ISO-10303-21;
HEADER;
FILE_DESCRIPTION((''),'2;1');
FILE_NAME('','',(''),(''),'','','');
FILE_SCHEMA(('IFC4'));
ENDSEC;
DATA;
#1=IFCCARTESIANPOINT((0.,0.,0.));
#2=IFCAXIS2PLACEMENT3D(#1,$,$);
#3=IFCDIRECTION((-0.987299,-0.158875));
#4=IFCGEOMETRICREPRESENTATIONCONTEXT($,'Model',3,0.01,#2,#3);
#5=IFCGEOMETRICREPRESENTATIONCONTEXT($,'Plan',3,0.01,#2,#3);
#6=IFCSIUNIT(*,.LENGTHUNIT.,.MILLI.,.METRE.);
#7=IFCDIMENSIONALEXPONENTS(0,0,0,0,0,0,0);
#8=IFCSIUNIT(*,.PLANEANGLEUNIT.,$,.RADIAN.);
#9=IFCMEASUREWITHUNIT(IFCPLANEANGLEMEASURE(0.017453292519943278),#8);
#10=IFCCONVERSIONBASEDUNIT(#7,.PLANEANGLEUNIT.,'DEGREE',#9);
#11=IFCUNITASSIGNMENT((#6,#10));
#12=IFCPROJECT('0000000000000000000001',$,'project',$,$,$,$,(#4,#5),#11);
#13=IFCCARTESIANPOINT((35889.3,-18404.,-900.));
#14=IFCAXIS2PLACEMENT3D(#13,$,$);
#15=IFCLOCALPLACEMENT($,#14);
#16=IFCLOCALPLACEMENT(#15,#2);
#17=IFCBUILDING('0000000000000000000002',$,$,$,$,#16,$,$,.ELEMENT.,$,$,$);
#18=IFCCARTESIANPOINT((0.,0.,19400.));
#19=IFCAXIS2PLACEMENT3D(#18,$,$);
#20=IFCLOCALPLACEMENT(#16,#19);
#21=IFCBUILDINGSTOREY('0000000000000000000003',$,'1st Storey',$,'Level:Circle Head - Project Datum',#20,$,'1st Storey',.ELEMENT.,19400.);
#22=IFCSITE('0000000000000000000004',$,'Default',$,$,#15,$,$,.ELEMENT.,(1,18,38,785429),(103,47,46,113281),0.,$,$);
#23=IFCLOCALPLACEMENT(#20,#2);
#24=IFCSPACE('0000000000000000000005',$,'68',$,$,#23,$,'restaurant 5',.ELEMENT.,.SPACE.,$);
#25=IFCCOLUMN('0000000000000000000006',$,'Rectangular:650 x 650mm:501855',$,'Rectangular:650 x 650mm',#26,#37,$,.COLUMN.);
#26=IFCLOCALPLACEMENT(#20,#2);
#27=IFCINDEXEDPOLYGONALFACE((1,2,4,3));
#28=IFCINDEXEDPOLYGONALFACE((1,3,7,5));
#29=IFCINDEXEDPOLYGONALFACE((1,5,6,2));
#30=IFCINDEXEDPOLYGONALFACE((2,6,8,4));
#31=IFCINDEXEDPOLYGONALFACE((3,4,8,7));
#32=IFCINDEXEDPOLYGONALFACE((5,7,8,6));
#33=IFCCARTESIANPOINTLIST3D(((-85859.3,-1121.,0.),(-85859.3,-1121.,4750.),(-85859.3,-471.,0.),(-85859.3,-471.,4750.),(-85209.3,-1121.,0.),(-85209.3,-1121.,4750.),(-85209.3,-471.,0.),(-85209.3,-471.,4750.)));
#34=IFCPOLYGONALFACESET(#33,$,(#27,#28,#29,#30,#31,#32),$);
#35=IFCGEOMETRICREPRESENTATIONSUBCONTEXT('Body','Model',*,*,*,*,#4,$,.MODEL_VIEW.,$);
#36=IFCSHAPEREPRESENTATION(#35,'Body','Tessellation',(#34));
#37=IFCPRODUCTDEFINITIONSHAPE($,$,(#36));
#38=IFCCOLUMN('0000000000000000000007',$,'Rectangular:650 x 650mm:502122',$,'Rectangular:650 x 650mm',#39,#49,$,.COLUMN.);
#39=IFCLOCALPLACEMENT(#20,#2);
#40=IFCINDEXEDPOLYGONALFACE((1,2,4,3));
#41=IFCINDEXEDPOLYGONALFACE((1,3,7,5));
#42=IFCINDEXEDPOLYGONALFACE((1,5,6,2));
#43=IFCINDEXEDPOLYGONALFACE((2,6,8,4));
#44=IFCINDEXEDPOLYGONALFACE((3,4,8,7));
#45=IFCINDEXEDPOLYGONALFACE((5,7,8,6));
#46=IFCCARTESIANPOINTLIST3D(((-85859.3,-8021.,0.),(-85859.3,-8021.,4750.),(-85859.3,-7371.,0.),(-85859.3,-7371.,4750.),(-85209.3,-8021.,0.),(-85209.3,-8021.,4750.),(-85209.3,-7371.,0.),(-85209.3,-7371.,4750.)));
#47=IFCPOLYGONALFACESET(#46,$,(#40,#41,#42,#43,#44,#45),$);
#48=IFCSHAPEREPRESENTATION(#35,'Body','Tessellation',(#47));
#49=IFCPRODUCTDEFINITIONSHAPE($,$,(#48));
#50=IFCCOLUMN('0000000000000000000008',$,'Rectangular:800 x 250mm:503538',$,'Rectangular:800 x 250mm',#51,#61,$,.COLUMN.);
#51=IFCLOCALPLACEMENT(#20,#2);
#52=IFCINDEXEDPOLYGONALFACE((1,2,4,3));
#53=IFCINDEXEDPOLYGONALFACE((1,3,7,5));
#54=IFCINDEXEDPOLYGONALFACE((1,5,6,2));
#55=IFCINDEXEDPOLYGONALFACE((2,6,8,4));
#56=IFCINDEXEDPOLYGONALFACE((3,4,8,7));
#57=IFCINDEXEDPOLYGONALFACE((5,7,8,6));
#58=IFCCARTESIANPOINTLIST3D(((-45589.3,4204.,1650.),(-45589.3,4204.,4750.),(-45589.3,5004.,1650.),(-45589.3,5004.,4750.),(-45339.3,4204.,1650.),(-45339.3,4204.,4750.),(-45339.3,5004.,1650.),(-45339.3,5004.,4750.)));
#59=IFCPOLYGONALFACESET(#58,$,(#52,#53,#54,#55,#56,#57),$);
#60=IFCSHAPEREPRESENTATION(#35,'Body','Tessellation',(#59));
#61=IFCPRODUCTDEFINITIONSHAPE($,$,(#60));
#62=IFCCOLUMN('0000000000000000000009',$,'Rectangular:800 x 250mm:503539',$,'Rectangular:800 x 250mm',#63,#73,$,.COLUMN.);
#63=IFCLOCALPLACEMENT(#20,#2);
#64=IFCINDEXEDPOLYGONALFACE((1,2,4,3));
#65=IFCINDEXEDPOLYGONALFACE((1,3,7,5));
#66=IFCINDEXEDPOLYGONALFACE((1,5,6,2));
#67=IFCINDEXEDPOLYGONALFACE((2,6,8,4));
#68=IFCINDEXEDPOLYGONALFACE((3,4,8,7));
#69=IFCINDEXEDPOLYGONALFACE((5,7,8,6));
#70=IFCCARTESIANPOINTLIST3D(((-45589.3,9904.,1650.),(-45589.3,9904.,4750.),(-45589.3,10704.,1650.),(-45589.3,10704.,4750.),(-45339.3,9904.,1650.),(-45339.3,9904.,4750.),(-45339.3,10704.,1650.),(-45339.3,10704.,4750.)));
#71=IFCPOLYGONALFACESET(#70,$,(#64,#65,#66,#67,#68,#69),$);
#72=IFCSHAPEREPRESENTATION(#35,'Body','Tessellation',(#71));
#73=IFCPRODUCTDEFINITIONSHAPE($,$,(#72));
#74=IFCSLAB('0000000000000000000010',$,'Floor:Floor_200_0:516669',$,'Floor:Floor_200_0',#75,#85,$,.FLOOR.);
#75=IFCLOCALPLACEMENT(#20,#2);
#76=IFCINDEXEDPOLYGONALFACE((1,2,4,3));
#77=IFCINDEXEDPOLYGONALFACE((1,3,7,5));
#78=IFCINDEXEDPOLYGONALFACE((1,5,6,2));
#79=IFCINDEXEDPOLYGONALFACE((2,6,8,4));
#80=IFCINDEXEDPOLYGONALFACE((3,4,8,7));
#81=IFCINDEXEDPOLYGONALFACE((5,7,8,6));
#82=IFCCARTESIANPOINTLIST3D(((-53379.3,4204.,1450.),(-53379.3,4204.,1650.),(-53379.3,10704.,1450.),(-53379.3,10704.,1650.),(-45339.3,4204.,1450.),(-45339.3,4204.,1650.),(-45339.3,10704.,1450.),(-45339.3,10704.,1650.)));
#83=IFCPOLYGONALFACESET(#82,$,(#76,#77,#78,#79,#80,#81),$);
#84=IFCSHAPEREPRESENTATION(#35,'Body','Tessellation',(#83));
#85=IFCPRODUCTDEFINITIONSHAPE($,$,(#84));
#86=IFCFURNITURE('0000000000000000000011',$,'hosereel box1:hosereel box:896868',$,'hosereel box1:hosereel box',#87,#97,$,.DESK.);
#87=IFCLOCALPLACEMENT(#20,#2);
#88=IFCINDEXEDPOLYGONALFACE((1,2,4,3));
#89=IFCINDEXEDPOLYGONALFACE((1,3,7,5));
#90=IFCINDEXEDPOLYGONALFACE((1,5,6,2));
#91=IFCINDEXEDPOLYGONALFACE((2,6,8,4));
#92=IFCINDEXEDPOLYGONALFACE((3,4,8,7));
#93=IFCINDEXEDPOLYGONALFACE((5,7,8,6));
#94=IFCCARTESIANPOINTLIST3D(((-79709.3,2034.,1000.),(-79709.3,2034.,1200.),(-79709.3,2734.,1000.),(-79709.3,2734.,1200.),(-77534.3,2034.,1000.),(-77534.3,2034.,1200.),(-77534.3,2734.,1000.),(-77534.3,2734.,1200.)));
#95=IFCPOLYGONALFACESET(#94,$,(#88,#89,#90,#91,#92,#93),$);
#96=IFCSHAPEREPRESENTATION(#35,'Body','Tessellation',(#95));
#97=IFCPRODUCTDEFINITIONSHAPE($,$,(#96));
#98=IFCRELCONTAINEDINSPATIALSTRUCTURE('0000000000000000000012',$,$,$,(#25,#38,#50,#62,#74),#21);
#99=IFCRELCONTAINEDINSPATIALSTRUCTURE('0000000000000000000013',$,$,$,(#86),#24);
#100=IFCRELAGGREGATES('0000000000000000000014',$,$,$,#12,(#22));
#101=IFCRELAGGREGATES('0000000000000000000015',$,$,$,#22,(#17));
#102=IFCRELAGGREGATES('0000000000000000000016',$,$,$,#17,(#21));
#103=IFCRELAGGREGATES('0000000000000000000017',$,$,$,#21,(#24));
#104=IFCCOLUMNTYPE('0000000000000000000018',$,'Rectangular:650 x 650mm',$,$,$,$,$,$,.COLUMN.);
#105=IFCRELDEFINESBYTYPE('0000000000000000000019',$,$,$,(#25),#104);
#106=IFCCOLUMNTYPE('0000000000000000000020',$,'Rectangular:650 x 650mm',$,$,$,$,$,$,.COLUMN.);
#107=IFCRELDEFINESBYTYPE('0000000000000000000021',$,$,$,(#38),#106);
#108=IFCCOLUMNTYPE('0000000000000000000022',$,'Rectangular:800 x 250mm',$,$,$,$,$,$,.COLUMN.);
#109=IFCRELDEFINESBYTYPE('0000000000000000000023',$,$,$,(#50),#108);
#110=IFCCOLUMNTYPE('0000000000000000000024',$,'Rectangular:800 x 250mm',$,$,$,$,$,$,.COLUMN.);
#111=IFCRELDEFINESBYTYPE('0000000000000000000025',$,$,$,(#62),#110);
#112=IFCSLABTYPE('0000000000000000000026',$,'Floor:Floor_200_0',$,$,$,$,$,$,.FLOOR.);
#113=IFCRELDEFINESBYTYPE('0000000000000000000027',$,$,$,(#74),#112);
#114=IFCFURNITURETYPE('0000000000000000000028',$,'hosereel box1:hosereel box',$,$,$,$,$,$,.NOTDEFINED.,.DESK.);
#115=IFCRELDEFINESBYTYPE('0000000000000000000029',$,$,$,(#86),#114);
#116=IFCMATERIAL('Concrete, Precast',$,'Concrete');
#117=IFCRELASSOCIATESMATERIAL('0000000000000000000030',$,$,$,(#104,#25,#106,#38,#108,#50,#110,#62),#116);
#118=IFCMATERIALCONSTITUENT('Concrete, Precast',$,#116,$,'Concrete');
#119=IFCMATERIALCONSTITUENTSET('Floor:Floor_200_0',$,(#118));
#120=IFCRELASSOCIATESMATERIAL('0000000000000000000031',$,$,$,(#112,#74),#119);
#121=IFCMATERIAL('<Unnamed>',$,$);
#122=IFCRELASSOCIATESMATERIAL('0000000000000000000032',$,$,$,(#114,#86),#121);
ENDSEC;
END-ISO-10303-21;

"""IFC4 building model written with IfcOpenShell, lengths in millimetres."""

from ifc_helpers import new_model, entity, si_unit, converted_unit, direction, frame, origin, place, context, subcontext, project, spatial, indexed_curve, outline, extrude, source, transform, mapped, material, constituent, constituent_set, type_object, type_shapes, element, save


model = new_model("IFC4")

# Units and contexts
model_context = context("Model", 3, precision=0.01, world=origin(), true_north=direction((-0.987299, -0.158875)))
plan_context = context("Plan", 3, precision=0.01, world=origin(), true_north=direction((-0.987299, -0.158875)))
body_context = subcontext(model_context, "Body", "Model", "MODEL_VIEW")
ifc_project = project(units=[si_unit("LENGTHUNIT", "METRE", prefix="MILLI"), converted_unit("PLANEANGLEUNIT", "DEGREE", entity("IfcPlaneAngleMeasure", 0.017453292519943278), si_unit("PLANEANGLEUNIT", "RADIAN"), dimensions=[0, 0, 0, 0, 0, 0, 0])], contexts=[model_context, plan_context])

# Site, building, storey
site_placement = place(None, frame((35889.3, -18404.0, -900.0)))
site = spatial("IfcSite", under=ifc_project, at=site_placement, Name="Default", CompositionType="ELEMENT", RefLatitude=(1, 18, 38, 785429), RefLongitude=(103, 47, 46, 113281), RefElevation=0.0)
building_placement = place(site_placement, origin())
building = spatial("IfcBuilding", under=site, at=building_placement, CompositionType="ELEMENT")
storey_placement = place(building_placement, frame((0.0, 0.0, 19400.0)))
storey = spatial("IfcBuildingStorey", under=building, at=storey_placement, Name="1st Storey", ObjectType="Level:Circle Head - Project Datum", LongName="1st Storey", CompositionType="ELEMENT", Elevation=19400.0)

# Columns
ifc_material_1 = material(Name="Concrete, Precast", Category="Concrete")
column_type_1 = type_object("IfcColumnType", Name="Rectangular:650 x 650mm", PredefinedType="COLUMN", material=ifc_material_1)
shared_shape_1 = source(origin(), body_context, "Body", "SweptSolid", [
    extrude(outline(indexed_curve([(-325.0, -325.0), (325.0, -325.0), (325.0, 325.0), (-325.0, 325.0), (-325.0, -325.0)], self_intersect=False)), frame((-85534.3, -796.0, 19400.0), z_axis=(0.0, 0.0, 1.0), x_axis=(0.0, 1.0, 0.0)), (0.0, 0.0, 1.0), 4750.0),
])
type_shapes(column_type_1, [shared_shape_1])
column_1_placement = place(storey_placement, frame((0.0, 0.0, -19400.0)))
element("IfcColumn", 1, at=column_1_placement, inside=storey, type_object=column_type_1, material=ifc_material_1, Name="Rectangular:650 x 650mm:501855", ObjectType="Rectangular:650 x 650mm", PredefinedType="COLUMN", context=body_context, shape_type="MappedRepresentation", body=[
    mapped(shared_shape_1, transform((0.0, 0.0, 0.0), scale=1.0)),
])
column_type_2 = type_object("IfcColumnType", Name="Rectangular:650 x 650mm", PredefinedType="COLUMN", material=ifc_material_1)
shared_shape_2 = source(origin(), body_context, "Body", "SweptSolid", [
    extrude(outline(indexed_curve([(-325.0, -325.0), (325.0, -325.0), (325.0, 325.0), (-325.0, 325.0), (-325.0, -325.0)], self_intersect=False)), frame((-85534.3, -7696.0, 19400.0), z_axis=(0.0, 0.0, 1.0), x_axis=(0.0, 1.0, 0.0)), (0.0, 0.0, 1.0), 4750.0),
])
type_shapes(column_type_2, [shared_shape_2])
column_2_placement = place(storey_placement, frame((0.0, 0.0, -19400.0)))
element("IfcColumn", 2, at=column_2_placement, inside=storey, type_object=column_type_2, material=ifc_material_1, Name="Rectangular:650 x 650mm:502122", ObjectType="Rectangular:650 x 650mm", PredefinedType="COLUMN", context=body_context, shape_type="MappedRepresentation", body=[
    mapped(shared_shape_2, transform((0.0, 0.0, 0.0), scale=1.0)),
])
column_type_3 = type_object("IfcColumnType", Name="Rectangular:800 x 250mm", PredefinedType="COLUMN", material=ifc_material_1)
shared_shape_3 = source(origin(), body_context, "Body", "SweptSolid", [
    extrude(outline(indexed_curve([(-125.0, -400.0), (125.0, -400.0), (125.0, 400.0), (-125.0, 400.0), (-125.0, -400.0)], self_intersect=False)), frame((-45464.3, 4604.0, 21050.0)), (0.0, 0.0, 1.0), 3100.0),
])
type_shapes(column_type_3, [shared_shape_3])
column_3_placement = place(storey_placement, frame((0.0, 0.0, -19400.0)))
element("IfcColumn", 3, at=column_3_placement, inside=storey, type_object=column_type_3, material=ifc_material_1, Name="Rectangular:800 x 250mm:503538", ObjectType="Rectangular:800 x 250mm", PredefinedType="COLUMN", context=body_context, shape_type="MappedRepresentation", body=[
    mapped(shared_shape_3, transform((0.0, 0.0, 0.0), scale=1.0)),
])
column_type_4 = type_object("IfcColumnType", Name="Rectangular:800 x 250mm", PredefinedType="COLUMN", material=ifc_material_1)
shared_shape_4 = source(origin(), body_context, "Body", "SweptSolid", [
    extrude(outline(indexed_curve([(-125.0, -400.0), (125.0, -400.0), (125.0, 400.0), (-125.0, 400.0), (-125.0, -400.0)], self_intersect=False)), frame((-45464.3, 10304.0, 21050.0)), (0.0, 0.0, 1.0), 3100.0),
])
type_shapes(column_type_4, [shared_shape_4])
column_4_placement = place(storey_placement, frame((0.0, 0.0, -19400.0)))
element("IfcColumn", 4, at=column_4_placement, inside=storey, type_object=column_type_4, material=ifc_material_1, Name="Rectangular:800 x 250mm:503539", ObjectType="Rectangular:800 x 250mm", PredefinedType="COLUMN", context=body_context, shape_type="MappedRepresentation", body=[
    mapped(shared_shape_4, transform((0.0, 0.0, 0.0), scale=1.0)),
])

# Shared definitions
ifc_constituent_1 = constituent(ifc_material_1, Name="Concrete, Precast", Category="Concrete")
ifc_constituent_set_1 = constituent_set(constituents=[ifc_constituent_1], Name="Floor:Floor_200_0")
slab_type_1 = type_object("IfcSlabType", Name="Floor:Floor_200_0", PredefinedType="FLOOR", material=ifc_constituent_set_1)

# Slab
slab_1_placement = place(storey_placement, origin())
element("IfcSlab", 5, at=slab_1_placement, inside=storey, type_object=slab_type_1, material=ifc_constituent_set_1, Name="Floor:Floor_200_0:516669", ObjectType="Floor:Floor_200_0", PredefinedType="FLOOR", context=body_context, shape_type="SweptSolid", body=[
    extrude(outline(indexed_curve([(-3250.0, -4020.0), (3250.0, -4020.0), (3250.0, 4020.0), (-3250.0, 4020.0), (-3250.0, -4020.0)], self_intersect=False)), frame((-49359.3, 7454.0, 1650.0), z_axis=(0.0, 0.0, -1.0), x_axis=(0.0, 1.0, 0.0)), (0.0, 0.0, 1.0), 200.0),
])

# Shared definitions
space_placement = place(storey_placement, origin())
space = spatial("IfcSpace", under=storey, at=space_placement, Name="68", LongName="restaurant 5", CompositionType="ELEMENT", PredefinedType="SPACE")

# Furniture
ifc_material_2 = material(Name="<Unnamed>")
furniture_type = type_object("IfcFurnitureType", Name="hosereel box1:hosereel box", AssemblyPlace="NOTDEFINED", PredefinedType="DESK", material=ifc_material_2)
shared_shape_5 = source(origin(), body_context, "Body", "SweptSolid", [
    extrude(outline(indexed_curve([(-350.0, -1087.5), (350.0, -1087.5), (350.0, 1087.5), (-350.0, 1087.5), (-350.0, -1087.5)], self_intersect=False)), frame((-83527.0, 2384.0, 20400.0), z_axis=(0.0, 0.0, 1.0), x_axis=(0.0, 1.0, 0.0)), (0.0, 0.0, 1.0), 200.0),
])
type_shapes(furniture_type, [shared_shape_5])
furniture_placement = place(space_placement, frame((4905.1, 0.0, -19400.0)))
element("IfcFurniture", 6, at=furniture_placement, inside=space, type_object=furniture_type, material=ifc_material_2, Name="hosereel box1:hosereel box:896868", ObjectType="hosereel box1:hosereel box", PredefinedType="DESK", context=body_context, shape_type="MappedRepresentation", body=[
    mapped(shared_shape_5, transform((0.0, 0.0, 0.0), scale=1.0)),
])

save(model, "model.ifc")
